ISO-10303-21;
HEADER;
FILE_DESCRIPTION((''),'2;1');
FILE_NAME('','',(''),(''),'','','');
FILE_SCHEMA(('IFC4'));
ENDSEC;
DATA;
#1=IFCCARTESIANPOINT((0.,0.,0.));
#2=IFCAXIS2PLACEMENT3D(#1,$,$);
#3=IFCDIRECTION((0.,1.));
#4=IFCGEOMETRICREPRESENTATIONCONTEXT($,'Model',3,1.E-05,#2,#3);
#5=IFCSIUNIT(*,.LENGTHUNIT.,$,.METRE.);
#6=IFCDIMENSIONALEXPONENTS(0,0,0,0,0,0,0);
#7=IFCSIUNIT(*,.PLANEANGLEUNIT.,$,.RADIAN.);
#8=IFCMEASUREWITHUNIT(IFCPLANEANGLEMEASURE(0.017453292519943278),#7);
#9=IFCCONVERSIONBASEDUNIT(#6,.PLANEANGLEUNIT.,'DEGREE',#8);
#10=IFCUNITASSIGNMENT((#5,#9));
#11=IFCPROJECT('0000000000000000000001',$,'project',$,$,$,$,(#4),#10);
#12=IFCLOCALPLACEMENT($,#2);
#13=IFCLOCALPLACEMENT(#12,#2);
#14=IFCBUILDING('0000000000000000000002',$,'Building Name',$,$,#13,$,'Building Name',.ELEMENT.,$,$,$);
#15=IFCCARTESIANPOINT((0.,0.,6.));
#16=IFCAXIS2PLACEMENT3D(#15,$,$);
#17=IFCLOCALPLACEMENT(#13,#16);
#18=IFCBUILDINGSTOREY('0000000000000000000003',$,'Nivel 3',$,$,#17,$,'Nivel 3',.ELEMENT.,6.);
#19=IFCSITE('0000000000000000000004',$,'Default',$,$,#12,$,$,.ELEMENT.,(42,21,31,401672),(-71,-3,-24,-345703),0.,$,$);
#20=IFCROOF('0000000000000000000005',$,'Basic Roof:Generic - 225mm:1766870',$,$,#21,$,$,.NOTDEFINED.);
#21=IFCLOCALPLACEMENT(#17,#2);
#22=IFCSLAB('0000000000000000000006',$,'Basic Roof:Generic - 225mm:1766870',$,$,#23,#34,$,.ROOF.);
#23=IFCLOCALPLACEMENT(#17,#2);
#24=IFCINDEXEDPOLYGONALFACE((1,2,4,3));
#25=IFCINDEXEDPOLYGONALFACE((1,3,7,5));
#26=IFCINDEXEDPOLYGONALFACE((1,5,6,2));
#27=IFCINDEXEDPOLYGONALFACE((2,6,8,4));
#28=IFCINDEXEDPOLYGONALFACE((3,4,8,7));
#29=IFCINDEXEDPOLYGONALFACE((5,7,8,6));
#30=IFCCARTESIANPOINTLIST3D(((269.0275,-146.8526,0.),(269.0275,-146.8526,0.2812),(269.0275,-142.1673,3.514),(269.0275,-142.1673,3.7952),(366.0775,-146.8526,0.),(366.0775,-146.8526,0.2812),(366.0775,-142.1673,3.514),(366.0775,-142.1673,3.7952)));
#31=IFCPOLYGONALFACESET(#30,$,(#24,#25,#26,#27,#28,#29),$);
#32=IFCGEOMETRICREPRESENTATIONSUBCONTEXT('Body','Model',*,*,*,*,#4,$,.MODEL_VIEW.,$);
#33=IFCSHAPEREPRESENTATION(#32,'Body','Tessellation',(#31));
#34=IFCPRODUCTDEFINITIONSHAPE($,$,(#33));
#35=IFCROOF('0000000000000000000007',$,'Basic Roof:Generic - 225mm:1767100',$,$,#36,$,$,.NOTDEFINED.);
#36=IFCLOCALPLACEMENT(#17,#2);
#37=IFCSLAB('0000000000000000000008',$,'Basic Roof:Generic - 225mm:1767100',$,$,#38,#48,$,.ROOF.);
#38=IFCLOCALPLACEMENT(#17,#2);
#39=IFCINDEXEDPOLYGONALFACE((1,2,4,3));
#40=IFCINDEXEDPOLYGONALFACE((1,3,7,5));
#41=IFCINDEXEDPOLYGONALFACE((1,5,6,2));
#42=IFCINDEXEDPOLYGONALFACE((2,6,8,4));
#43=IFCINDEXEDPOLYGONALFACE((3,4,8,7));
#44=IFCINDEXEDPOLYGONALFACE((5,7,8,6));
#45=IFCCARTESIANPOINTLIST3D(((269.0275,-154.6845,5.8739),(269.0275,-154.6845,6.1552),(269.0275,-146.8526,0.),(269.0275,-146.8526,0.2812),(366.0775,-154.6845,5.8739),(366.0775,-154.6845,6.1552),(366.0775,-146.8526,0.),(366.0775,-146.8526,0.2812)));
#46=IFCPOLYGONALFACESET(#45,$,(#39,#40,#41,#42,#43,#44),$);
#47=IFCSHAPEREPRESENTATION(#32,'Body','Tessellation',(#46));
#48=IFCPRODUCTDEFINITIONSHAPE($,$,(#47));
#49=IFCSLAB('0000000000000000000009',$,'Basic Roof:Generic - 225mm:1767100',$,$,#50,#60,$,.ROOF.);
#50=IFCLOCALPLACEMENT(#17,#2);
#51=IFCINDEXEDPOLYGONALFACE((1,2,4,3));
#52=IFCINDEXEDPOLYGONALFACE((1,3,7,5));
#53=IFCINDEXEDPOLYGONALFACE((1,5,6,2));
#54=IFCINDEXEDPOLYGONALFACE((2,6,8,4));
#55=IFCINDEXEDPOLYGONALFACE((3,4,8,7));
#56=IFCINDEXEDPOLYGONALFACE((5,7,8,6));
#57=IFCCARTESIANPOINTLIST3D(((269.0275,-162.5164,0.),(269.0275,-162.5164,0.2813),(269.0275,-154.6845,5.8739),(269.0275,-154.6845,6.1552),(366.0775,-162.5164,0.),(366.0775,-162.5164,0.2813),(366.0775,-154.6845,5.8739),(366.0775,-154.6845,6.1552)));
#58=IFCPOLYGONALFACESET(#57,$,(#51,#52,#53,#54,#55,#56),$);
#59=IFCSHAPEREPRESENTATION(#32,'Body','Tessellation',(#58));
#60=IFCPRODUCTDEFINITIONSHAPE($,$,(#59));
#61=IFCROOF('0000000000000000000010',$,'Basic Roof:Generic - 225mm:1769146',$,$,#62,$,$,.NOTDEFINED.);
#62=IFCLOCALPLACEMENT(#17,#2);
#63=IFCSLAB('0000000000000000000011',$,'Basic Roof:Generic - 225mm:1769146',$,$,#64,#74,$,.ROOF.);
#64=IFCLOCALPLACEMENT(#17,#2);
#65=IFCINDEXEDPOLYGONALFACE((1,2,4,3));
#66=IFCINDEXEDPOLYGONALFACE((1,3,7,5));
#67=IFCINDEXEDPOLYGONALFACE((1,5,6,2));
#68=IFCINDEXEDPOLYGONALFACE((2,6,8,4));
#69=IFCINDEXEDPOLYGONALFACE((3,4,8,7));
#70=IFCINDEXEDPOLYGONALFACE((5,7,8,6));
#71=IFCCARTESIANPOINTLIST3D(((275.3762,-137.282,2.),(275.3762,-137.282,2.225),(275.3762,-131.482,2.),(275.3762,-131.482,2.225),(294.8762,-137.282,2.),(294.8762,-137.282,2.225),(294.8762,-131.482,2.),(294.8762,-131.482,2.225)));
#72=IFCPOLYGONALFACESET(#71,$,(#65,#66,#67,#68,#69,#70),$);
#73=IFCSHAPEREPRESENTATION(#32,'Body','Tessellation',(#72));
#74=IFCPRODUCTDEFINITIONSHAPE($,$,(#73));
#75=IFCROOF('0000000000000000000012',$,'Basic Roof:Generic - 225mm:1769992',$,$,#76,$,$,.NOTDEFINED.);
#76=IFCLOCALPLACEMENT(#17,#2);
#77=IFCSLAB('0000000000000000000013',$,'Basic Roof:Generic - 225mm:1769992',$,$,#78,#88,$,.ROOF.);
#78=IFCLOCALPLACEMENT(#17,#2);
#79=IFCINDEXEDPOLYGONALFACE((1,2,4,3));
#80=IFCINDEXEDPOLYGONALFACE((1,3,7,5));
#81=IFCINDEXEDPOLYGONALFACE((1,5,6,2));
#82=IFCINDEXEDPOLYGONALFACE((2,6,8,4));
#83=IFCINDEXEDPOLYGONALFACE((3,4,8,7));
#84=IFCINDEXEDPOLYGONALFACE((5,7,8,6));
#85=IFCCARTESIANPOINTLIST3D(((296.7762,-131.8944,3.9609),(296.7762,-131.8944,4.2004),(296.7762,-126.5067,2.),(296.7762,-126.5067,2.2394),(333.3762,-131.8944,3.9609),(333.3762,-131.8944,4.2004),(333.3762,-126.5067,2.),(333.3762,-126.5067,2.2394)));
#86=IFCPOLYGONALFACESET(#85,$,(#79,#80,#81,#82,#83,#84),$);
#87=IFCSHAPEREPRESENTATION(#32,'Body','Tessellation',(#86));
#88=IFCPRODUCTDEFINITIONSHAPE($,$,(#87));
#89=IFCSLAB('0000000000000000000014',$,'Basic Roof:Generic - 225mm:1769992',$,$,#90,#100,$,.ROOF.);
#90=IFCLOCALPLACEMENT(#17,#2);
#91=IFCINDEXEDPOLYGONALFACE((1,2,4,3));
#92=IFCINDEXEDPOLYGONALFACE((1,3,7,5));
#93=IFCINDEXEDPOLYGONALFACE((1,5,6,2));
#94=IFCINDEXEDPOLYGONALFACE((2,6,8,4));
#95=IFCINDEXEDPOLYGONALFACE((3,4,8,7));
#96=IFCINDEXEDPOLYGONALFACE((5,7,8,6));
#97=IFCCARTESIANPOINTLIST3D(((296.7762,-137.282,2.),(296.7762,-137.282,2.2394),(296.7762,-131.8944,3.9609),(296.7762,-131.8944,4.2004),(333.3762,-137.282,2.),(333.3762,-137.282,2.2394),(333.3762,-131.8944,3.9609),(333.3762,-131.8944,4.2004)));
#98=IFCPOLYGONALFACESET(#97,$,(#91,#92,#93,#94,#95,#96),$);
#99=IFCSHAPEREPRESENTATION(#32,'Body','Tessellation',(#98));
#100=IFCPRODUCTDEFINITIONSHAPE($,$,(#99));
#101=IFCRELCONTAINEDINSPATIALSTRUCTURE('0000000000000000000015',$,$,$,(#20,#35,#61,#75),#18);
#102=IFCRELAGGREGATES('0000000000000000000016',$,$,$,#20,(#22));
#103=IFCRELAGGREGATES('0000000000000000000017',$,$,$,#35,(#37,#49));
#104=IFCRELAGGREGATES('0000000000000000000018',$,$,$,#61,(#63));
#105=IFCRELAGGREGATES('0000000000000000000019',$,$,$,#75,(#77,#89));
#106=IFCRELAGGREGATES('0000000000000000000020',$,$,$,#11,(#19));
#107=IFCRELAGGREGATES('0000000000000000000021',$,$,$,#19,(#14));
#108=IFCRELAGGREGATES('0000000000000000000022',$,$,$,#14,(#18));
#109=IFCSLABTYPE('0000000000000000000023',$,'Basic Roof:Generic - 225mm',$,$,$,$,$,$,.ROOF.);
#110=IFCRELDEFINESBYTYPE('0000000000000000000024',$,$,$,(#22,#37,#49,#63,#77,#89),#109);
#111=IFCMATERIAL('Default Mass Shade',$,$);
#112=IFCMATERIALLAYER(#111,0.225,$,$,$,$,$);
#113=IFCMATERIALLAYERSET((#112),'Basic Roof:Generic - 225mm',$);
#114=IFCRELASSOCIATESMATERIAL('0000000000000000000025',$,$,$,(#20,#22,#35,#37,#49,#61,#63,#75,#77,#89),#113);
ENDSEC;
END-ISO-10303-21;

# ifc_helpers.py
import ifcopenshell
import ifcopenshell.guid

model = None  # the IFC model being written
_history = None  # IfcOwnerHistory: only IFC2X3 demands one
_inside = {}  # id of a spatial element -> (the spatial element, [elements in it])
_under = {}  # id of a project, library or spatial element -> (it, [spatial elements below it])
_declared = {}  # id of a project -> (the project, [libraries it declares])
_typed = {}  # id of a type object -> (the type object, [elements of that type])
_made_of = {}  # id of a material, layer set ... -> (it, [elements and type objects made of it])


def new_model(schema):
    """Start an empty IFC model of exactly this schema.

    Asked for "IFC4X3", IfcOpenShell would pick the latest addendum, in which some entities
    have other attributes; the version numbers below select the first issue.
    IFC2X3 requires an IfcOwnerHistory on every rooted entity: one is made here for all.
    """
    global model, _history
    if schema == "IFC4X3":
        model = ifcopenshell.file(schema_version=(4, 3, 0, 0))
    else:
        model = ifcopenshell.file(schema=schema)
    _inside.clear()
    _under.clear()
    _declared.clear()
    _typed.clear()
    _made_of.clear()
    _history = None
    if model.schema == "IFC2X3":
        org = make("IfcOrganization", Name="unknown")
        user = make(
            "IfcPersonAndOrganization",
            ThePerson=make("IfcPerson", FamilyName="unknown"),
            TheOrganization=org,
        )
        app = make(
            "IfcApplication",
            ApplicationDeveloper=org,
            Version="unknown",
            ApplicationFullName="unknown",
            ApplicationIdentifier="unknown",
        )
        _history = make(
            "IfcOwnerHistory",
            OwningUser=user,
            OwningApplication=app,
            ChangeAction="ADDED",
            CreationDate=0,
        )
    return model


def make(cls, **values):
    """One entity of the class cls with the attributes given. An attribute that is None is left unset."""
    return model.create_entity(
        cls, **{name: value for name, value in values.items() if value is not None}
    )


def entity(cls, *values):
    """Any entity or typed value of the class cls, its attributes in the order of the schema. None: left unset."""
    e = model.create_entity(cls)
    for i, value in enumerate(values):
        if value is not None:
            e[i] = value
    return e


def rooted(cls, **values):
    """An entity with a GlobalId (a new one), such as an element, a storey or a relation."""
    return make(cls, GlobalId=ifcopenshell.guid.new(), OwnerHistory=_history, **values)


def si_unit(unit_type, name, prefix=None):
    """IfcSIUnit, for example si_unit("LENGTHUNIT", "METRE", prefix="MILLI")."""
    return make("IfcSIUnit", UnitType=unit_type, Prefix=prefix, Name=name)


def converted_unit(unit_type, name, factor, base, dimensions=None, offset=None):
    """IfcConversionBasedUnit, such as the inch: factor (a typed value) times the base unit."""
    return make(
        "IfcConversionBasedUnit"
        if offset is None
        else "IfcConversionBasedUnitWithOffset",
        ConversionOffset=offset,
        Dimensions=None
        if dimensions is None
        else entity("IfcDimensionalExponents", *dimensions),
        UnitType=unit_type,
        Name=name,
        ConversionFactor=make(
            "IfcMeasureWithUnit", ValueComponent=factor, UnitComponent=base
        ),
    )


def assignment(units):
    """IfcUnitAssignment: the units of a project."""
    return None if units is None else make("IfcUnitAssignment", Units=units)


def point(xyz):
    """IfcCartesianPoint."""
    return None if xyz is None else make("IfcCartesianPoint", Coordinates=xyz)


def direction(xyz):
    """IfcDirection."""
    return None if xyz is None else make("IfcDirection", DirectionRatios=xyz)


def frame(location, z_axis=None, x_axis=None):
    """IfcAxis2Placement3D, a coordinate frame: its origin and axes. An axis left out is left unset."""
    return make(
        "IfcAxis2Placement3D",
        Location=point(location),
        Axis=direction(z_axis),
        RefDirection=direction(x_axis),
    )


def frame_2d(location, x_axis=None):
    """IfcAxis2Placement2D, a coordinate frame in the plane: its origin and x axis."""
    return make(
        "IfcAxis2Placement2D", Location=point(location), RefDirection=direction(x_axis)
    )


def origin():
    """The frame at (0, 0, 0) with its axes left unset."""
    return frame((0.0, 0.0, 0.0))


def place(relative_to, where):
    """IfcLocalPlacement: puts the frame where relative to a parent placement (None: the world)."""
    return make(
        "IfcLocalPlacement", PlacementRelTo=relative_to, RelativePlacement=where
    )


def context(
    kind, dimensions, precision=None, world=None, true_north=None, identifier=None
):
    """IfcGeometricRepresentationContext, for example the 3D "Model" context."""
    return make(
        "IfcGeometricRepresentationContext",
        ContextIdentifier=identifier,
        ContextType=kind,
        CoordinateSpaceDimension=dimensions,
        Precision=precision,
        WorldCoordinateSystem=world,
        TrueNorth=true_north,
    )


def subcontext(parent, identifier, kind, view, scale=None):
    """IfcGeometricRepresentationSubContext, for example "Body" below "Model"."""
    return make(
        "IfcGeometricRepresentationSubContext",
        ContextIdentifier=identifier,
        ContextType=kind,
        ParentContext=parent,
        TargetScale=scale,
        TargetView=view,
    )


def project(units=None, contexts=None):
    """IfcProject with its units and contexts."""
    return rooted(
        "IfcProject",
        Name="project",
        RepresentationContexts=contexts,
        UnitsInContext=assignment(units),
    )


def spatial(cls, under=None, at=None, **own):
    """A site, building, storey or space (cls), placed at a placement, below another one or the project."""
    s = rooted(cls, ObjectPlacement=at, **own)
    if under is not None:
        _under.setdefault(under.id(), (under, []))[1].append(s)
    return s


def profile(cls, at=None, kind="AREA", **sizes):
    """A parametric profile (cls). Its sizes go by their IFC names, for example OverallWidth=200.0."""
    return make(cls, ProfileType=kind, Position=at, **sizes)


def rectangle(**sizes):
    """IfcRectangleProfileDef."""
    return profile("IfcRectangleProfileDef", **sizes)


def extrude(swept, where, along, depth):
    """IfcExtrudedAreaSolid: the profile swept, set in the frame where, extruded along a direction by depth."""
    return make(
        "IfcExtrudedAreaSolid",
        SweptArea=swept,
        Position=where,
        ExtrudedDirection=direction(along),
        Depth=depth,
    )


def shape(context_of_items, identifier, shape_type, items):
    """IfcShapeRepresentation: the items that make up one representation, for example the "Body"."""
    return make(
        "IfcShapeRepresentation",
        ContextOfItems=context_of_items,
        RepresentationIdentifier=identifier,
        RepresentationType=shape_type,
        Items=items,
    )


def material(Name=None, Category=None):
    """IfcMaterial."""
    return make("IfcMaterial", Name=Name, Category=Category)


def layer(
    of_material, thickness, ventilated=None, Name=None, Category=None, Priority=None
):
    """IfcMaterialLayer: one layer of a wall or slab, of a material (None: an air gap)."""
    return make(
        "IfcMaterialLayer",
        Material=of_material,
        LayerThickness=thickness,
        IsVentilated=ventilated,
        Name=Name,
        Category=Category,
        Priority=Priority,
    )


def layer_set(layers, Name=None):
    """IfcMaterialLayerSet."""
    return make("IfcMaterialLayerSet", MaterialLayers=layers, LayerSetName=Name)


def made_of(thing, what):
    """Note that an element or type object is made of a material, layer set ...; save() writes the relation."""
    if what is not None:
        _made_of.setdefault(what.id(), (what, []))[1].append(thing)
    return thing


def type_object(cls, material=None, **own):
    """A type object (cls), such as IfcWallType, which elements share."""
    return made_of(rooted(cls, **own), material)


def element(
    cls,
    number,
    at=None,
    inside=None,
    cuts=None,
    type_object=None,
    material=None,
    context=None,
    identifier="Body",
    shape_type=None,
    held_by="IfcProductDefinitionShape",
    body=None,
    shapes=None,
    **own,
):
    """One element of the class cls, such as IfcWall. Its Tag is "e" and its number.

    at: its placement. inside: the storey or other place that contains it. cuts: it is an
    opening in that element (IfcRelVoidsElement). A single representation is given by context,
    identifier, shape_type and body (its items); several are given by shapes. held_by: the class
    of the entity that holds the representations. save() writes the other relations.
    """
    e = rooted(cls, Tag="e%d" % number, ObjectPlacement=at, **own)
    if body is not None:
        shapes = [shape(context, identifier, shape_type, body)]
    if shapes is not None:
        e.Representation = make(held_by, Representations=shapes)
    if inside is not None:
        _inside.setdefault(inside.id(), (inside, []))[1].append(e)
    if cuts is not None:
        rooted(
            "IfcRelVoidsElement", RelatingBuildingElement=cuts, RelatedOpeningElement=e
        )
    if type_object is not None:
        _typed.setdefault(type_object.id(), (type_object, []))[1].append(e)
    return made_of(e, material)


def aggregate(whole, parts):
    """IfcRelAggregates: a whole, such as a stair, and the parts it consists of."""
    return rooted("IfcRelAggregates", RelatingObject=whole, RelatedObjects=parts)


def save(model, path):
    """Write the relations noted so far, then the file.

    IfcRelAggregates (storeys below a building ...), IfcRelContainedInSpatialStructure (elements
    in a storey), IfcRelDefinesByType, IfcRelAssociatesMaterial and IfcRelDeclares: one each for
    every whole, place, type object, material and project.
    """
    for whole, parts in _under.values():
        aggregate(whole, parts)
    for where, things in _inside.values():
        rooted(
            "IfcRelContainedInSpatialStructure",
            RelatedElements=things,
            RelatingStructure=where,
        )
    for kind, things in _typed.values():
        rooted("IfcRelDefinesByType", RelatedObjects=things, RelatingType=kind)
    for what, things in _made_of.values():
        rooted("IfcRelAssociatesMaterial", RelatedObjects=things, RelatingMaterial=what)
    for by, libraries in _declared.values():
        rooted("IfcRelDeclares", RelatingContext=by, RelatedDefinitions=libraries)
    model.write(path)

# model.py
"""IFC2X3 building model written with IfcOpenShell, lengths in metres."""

from ifc_helpers import new_model, entity, si_unit, converted_unit, direction, frame, frame_2d, origin, place, context, subcontext, project, spatial, rectangle, extrude, material, layer, layer_set, type_object, element, aggregate, save


model = new_model("IFC2X3")

# Units and contexts
model_context = context("Model", 3, precision=1e-05, world=origin(), true_north=direction((0.0, 1.0)))
body_context = subcontext(model_context, "Body", "Model", "MODEL_VIEW")
ifc_project = project(units=[si_unit("LENGTHUNIT", "METRE"), converted_unit("PLANEANGLEUNIT", "DEGREE", entity("IfcPlaneAngleMeasure", 0.017453292519943278), si_unit("PLANEANGLEUNIT", "RADIAN"), dimensions=[0, 0, 0, 0, 0, 0, 0])], contexts=[model_context])

# Site, building, storey
site_placement = place(None, origin())
site = spatial("IfcSite", under=ifc_project, at=site_placement, Name="Default", CompositionType="ELEMENT", RefLatitude=(42, 21, 31, 401672), RefLongitude=(-71, -3, -24, -345703), RefElevation=0.0)
building_placement = place(site_placement, origin())
building = spatial("IfcBuilding", under=site, at=building_placement, Name="Building Name", LongName="Building Name", CompositionType="ELEMENT")
storey_placement = place(building_placement, frame((0.0, 0.0, 6.0)))
storey = spatial("IfcBuildingStorey", under=building, at=storey_placement, Name="Nivel 3", LongName="Nivel 3", CompositionType="ELEMENT", Elevation=6.0)

# Shared definitions
ifc_material = material(Name="Default Mass Shade")
ifc_layer = layer(ifc_material, 0.225)
ifc_layer_set = layer_set([ifc_layer], Name="Basic Roof:Generic - 225mm")
slab_type = type_object("IfcSlabType", Name="Basic Roof:Generic - 225mm", PredefinedType="ROOF")

# Roofs, slabs
roof_1_placement = place(storey_placement, frame((269.0275, -146.8526, 0.0)))
roof_1 = element("IfcRoof", 1, at=roof_1_placement, inside=storey, material=ifc_layer_set, Name="Basic Roof:Generic - 225mm:1766870", ShapeType="NOTDEFINED")
slab_1_placement = place(roof_1_placement, origin())
slab_1 = element("IfcSlab", 2, at=slab_1_placement, type_object=slab_type, material=ifc_layer_set, Name="Basic Roof:Generic - 225mm:1766870", PredefinedType="ROOF", context=body_context, shape_type="SweptSolid", body=[
    extrude(rectangle(XDim=97.05, YDim=5.8566, at=frame_2d((0.0, 0.0), x_axis=(-1.0, 0.0))), frame((48.525, 2.3426, 1.757), z_axis=(0.0, -0.6, 0.8), x_axis=(1.0, 0.0, 0.0)), (0.0, 0.6, 0.8), 0.2812),
])
aggregate(roof_1, [slab_1])
roof_2_placement = place(storey_placement, frame((269.0275, -162.5164, 0.0)))
roof_2 = element("IfcRoof", 3, at=roof_2_placement, inside=storey, material=ifc_layer_set, Name="Basic Roof:Generic - 225mm:1767100", ShapeType="NOTDEFINED")
slab_2_placement = place(roof_2_placement, origin())
slab_2 = element("IfcSlab", 4, at=slab_2_placement, type_object=slab_type, material=ifc_layer_set, Name="Basic Roof:Generic - 225mm:1767100", PredefinedType="ROOF", context=body_context, shape_type="SweptSolid", body=[
    extrude(rectangle(XDim=9.7899, YDim=97.05, at=frame_2d((0.0, 0.0), x_axis=(0.0, -1.0))), frame((48.525, 11.7479, 2.937), z_axis=(0.0, 0.6, 0.8), x_axis=(1.0, 0.0, 0.0)), (0.0, -0.6, 0.8), 0.2813),
])
slab_3_placement = place(roof_2_placement, origin())
slab_3 = element("IfcSlab", 5, at=slab_3_placement, type_object=slab_type, material=ifc_layer_set, Name="Basic Roof:Generic - 225mm:1767100", PredefinedType="ROOF", context=body_context, shape_type="SweptSolid", body=[
    extrude(rectangle(XDim=97.05, YDim=9.7899, at=frame_2d((0.0, 0.0), x_axis=(-1.0, 0.0))), frame((48.525, 3.916, 2.937), z_axis=(0.0, -0.6, 0.8), x_axis=(1.0, 0.0, 0.0)), (0.0, 0.6, 0.8), 0.2813),
])
aggregate(roof_2, [slab_2, slab_3])

# Roof, slab
roof_3_placement = place(storey_placement, frame((275.3762, -137.282, 2.0)))
roof_3 = element("IfcRoof", 6, at=roof_3_placement, inside=storey, material=ifc_layer_set, Name="Basic Roof:Generic - 225mm:1769146", ShapeType="NOTDEFINED")
slab_4_placement = place(roof_3_placement, origin())
slab_4 = element("IfcSlab", 7, at=slab_4_placement, type_object=slab_type, material=ifc_layer_set, Name="Basic Roof:Generic - 225mm:1769146", PredefinedType="ROOF", context=body_context, shape_type="SweptSolid", body=[
    extrude(rectangle(XDim=19.5, YDim=5.8, at=frame_2d((0.0, 0.0), x_axis=(1.0, 0.0))), frame((9.75, 2.9, 0.0)), (0.0, 0.0, 1.0), 0.225),
])
aggregate(roof_3, [slab_4])

# Roof, slabs
roof_4_placement = place(storey_placement, frame((296.7762, -137.282, 2.0)))
roof_4 = element("IfcRoof", 8, at=roof_4_placement, inside=storey, material=ifc_layer_set, Name="Basic Roof:Generic - 225mm:1769992", ShapeType="NOTDEFINED")
slab_5_placement = place(roof_4_placement, origin())
slab_5 = element("IfcSlab", 9, at=slab_5_placement, type_object=slab_type, material=ifc_layer_set, Name="Basic Roof:Generic - 225mm:1769992", PredefinedType="ROOF", context=body_context, shape_type="SweptSolid", body=[
    extrude(rectangle(XDim=36.6, YDim=5.7334, at=frame_2d((0.0, 0.0), x_axis=(1.0, 0.0))), frame((18.3, 8.0814, 0.9805), z_axis=(0.0, 0.34202, 0.939693), x_axis=(1.0, 0.0, 0.0)), (0.0, -0.34202, 0.939693), 0.2394),
])
slab_6_placement = place(roof_4_placement, origin())
slab_6 = element("IfcSlab", 10, at=slab_6_placement, type_object=slab_type, material=ifc_layer_set, Name="Basic Roof:Generic - 225mm:1769992", PredefinedType="ROOF", context=body_context, shape_type="SweptSolid", body=[
    extrude(rectangle(XDim=5.7334, YDim=36.6, at=frame_2d((0.0, 0.0), x_axis=(0.0, 1.0))), frame((18.3, 2.6938, 0.9805), z_axis=(0.0, -0.34202, 0.939693), x_axis=(1.0, 0.0, 0.0)), (0.0, 0.34202, 0.939693), 0.2394),
])
aggregate(roof_4, [slab_5, slab_6])

save(model, "model.ifc")
